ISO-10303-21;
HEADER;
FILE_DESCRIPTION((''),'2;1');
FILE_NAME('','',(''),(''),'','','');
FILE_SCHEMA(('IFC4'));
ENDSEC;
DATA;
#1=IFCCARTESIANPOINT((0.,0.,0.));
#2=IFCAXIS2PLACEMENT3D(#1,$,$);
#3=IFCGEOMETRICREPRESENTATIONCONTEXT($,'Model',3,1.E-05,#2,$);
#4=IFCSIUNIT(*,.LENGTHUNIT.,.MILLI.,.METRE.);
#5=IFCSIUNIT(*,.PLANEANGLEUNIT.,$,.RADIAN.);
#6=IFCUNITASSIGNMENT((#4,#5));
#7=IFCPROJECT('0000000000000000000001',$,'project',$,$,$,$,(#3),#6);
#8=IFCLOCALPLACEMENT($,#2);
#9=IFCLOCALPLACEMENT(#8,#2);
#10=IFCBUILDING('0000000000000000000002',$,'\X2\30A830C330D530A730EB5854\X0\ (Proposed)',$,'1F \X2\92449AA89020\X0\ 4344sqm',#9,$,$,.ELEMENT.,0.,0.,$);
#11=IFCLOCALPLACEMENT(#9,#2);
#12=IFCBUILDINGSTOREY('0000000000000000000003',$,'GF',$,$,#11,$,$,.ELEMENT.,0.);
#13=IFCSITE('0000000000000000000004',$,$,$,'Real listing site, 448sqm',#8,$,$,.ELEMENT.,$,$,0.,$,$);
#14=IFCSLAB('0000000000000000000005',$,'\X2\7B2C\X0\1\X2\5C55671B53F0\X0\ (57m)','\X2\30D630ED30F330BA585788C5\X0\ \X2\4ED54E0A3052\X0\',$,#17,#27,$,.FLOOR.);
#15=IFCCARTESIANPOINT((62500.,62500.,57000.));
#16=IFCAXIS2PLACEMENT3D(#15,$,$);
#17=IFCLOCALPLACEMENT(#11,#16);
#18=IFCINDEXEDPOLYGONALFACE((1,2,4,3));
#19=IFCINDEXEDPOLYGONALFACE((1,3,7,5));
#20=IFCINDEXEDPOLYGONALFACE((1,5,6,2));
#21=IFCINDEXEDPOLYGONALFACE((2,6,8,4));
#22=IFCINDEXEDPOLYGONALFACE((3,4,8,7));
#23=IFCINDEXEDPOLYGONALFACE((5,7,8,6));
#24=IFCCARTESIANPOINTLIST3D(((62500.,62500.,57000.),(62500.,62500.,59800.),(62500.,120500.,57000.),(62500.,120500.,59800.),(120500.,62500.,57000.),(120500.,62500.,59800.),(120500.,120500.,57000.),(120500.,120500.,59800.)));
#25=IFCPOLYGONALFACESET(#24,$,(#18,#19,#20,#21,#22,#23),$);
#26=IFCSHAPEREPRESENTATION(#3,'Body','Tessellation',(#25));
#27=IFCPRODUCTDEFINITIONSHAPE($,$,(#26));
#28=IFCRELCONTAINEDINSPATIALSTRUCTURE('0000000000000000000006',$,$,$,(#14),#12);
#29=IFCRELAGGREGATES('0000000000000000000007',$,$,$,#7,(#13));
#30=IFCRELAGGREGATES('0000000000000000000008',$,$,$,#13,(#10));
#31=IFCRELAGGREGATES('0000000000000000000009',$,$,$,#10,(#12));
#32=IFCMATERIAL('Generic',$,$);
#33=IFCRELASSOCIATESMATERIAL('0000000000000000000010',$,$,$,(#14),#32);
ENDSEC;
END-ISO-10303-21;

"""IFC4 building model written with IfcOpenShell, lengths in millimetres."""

from ifc_helpers import new_model, si_unit, frame, frame_2d, origin, place, context, project, spatial, rectangle, extrude, material, element, save


model = new_model("IFC4")

# Units and contexts
model_context = context("Model", 3, precision=1e-05, world=origin())
ifc_project = project(units=[si_unit("LENGTHUNIT", "METRE", prefix="MILLI"), si_unit("PLANEANGLEUNIT", "RADIAN")], contexts=[model_context])

# Site, building, storey
site_placement = place(None, origin())
site = spatial("IfcSite", under=ifc_project, at=site_placement, ObjectType="Real listing site, 448sqm", CompositionType="ELEMENT", RefElevation=0.0)
building_placement = place(site_placement, origin())
building = spatial("IfcBuilding", under=site, at=building_placement, Name="エッフェル塔 (Proposed)", ObjectType="1F 鉄骨造 4344sqm", CompositionType="ELEMENT", ElevationOfRefHeight=0.0, ElevationOfTerrain=0.0)
storey_placement = place(building_placement, origin())
storey = spatial("IfcBuildingStorey", under=building, at=storey_placement, Name="GF", CompositionType="ELEMENT", Elevation=0.0)

# Shared definitions
ifc_material = material(Name="Generic")

# Slab
slab_placement = place(storey_placement, frame((62500.0, 62500.0, 57000.0)))
element("IfcSlab", 1, at=slab_placement, inside=storey, material=ifc_material, Name="第1展望台 (57m)", Description="ブロンズ塗装 仕上げ", PredefinedType="FLOOR", context=model_context, shape_type="SweptSolid", body=[
    extrude(rectangle(XDim=58000.0, YDim=58000.0, at=frame_2d((29000.0, 29000.0))), frame((62500.0, 62500.0, 57000.0)), (0.0, 0.0, 1.0), 2800.0),
])

save(model, "model.ifc")
